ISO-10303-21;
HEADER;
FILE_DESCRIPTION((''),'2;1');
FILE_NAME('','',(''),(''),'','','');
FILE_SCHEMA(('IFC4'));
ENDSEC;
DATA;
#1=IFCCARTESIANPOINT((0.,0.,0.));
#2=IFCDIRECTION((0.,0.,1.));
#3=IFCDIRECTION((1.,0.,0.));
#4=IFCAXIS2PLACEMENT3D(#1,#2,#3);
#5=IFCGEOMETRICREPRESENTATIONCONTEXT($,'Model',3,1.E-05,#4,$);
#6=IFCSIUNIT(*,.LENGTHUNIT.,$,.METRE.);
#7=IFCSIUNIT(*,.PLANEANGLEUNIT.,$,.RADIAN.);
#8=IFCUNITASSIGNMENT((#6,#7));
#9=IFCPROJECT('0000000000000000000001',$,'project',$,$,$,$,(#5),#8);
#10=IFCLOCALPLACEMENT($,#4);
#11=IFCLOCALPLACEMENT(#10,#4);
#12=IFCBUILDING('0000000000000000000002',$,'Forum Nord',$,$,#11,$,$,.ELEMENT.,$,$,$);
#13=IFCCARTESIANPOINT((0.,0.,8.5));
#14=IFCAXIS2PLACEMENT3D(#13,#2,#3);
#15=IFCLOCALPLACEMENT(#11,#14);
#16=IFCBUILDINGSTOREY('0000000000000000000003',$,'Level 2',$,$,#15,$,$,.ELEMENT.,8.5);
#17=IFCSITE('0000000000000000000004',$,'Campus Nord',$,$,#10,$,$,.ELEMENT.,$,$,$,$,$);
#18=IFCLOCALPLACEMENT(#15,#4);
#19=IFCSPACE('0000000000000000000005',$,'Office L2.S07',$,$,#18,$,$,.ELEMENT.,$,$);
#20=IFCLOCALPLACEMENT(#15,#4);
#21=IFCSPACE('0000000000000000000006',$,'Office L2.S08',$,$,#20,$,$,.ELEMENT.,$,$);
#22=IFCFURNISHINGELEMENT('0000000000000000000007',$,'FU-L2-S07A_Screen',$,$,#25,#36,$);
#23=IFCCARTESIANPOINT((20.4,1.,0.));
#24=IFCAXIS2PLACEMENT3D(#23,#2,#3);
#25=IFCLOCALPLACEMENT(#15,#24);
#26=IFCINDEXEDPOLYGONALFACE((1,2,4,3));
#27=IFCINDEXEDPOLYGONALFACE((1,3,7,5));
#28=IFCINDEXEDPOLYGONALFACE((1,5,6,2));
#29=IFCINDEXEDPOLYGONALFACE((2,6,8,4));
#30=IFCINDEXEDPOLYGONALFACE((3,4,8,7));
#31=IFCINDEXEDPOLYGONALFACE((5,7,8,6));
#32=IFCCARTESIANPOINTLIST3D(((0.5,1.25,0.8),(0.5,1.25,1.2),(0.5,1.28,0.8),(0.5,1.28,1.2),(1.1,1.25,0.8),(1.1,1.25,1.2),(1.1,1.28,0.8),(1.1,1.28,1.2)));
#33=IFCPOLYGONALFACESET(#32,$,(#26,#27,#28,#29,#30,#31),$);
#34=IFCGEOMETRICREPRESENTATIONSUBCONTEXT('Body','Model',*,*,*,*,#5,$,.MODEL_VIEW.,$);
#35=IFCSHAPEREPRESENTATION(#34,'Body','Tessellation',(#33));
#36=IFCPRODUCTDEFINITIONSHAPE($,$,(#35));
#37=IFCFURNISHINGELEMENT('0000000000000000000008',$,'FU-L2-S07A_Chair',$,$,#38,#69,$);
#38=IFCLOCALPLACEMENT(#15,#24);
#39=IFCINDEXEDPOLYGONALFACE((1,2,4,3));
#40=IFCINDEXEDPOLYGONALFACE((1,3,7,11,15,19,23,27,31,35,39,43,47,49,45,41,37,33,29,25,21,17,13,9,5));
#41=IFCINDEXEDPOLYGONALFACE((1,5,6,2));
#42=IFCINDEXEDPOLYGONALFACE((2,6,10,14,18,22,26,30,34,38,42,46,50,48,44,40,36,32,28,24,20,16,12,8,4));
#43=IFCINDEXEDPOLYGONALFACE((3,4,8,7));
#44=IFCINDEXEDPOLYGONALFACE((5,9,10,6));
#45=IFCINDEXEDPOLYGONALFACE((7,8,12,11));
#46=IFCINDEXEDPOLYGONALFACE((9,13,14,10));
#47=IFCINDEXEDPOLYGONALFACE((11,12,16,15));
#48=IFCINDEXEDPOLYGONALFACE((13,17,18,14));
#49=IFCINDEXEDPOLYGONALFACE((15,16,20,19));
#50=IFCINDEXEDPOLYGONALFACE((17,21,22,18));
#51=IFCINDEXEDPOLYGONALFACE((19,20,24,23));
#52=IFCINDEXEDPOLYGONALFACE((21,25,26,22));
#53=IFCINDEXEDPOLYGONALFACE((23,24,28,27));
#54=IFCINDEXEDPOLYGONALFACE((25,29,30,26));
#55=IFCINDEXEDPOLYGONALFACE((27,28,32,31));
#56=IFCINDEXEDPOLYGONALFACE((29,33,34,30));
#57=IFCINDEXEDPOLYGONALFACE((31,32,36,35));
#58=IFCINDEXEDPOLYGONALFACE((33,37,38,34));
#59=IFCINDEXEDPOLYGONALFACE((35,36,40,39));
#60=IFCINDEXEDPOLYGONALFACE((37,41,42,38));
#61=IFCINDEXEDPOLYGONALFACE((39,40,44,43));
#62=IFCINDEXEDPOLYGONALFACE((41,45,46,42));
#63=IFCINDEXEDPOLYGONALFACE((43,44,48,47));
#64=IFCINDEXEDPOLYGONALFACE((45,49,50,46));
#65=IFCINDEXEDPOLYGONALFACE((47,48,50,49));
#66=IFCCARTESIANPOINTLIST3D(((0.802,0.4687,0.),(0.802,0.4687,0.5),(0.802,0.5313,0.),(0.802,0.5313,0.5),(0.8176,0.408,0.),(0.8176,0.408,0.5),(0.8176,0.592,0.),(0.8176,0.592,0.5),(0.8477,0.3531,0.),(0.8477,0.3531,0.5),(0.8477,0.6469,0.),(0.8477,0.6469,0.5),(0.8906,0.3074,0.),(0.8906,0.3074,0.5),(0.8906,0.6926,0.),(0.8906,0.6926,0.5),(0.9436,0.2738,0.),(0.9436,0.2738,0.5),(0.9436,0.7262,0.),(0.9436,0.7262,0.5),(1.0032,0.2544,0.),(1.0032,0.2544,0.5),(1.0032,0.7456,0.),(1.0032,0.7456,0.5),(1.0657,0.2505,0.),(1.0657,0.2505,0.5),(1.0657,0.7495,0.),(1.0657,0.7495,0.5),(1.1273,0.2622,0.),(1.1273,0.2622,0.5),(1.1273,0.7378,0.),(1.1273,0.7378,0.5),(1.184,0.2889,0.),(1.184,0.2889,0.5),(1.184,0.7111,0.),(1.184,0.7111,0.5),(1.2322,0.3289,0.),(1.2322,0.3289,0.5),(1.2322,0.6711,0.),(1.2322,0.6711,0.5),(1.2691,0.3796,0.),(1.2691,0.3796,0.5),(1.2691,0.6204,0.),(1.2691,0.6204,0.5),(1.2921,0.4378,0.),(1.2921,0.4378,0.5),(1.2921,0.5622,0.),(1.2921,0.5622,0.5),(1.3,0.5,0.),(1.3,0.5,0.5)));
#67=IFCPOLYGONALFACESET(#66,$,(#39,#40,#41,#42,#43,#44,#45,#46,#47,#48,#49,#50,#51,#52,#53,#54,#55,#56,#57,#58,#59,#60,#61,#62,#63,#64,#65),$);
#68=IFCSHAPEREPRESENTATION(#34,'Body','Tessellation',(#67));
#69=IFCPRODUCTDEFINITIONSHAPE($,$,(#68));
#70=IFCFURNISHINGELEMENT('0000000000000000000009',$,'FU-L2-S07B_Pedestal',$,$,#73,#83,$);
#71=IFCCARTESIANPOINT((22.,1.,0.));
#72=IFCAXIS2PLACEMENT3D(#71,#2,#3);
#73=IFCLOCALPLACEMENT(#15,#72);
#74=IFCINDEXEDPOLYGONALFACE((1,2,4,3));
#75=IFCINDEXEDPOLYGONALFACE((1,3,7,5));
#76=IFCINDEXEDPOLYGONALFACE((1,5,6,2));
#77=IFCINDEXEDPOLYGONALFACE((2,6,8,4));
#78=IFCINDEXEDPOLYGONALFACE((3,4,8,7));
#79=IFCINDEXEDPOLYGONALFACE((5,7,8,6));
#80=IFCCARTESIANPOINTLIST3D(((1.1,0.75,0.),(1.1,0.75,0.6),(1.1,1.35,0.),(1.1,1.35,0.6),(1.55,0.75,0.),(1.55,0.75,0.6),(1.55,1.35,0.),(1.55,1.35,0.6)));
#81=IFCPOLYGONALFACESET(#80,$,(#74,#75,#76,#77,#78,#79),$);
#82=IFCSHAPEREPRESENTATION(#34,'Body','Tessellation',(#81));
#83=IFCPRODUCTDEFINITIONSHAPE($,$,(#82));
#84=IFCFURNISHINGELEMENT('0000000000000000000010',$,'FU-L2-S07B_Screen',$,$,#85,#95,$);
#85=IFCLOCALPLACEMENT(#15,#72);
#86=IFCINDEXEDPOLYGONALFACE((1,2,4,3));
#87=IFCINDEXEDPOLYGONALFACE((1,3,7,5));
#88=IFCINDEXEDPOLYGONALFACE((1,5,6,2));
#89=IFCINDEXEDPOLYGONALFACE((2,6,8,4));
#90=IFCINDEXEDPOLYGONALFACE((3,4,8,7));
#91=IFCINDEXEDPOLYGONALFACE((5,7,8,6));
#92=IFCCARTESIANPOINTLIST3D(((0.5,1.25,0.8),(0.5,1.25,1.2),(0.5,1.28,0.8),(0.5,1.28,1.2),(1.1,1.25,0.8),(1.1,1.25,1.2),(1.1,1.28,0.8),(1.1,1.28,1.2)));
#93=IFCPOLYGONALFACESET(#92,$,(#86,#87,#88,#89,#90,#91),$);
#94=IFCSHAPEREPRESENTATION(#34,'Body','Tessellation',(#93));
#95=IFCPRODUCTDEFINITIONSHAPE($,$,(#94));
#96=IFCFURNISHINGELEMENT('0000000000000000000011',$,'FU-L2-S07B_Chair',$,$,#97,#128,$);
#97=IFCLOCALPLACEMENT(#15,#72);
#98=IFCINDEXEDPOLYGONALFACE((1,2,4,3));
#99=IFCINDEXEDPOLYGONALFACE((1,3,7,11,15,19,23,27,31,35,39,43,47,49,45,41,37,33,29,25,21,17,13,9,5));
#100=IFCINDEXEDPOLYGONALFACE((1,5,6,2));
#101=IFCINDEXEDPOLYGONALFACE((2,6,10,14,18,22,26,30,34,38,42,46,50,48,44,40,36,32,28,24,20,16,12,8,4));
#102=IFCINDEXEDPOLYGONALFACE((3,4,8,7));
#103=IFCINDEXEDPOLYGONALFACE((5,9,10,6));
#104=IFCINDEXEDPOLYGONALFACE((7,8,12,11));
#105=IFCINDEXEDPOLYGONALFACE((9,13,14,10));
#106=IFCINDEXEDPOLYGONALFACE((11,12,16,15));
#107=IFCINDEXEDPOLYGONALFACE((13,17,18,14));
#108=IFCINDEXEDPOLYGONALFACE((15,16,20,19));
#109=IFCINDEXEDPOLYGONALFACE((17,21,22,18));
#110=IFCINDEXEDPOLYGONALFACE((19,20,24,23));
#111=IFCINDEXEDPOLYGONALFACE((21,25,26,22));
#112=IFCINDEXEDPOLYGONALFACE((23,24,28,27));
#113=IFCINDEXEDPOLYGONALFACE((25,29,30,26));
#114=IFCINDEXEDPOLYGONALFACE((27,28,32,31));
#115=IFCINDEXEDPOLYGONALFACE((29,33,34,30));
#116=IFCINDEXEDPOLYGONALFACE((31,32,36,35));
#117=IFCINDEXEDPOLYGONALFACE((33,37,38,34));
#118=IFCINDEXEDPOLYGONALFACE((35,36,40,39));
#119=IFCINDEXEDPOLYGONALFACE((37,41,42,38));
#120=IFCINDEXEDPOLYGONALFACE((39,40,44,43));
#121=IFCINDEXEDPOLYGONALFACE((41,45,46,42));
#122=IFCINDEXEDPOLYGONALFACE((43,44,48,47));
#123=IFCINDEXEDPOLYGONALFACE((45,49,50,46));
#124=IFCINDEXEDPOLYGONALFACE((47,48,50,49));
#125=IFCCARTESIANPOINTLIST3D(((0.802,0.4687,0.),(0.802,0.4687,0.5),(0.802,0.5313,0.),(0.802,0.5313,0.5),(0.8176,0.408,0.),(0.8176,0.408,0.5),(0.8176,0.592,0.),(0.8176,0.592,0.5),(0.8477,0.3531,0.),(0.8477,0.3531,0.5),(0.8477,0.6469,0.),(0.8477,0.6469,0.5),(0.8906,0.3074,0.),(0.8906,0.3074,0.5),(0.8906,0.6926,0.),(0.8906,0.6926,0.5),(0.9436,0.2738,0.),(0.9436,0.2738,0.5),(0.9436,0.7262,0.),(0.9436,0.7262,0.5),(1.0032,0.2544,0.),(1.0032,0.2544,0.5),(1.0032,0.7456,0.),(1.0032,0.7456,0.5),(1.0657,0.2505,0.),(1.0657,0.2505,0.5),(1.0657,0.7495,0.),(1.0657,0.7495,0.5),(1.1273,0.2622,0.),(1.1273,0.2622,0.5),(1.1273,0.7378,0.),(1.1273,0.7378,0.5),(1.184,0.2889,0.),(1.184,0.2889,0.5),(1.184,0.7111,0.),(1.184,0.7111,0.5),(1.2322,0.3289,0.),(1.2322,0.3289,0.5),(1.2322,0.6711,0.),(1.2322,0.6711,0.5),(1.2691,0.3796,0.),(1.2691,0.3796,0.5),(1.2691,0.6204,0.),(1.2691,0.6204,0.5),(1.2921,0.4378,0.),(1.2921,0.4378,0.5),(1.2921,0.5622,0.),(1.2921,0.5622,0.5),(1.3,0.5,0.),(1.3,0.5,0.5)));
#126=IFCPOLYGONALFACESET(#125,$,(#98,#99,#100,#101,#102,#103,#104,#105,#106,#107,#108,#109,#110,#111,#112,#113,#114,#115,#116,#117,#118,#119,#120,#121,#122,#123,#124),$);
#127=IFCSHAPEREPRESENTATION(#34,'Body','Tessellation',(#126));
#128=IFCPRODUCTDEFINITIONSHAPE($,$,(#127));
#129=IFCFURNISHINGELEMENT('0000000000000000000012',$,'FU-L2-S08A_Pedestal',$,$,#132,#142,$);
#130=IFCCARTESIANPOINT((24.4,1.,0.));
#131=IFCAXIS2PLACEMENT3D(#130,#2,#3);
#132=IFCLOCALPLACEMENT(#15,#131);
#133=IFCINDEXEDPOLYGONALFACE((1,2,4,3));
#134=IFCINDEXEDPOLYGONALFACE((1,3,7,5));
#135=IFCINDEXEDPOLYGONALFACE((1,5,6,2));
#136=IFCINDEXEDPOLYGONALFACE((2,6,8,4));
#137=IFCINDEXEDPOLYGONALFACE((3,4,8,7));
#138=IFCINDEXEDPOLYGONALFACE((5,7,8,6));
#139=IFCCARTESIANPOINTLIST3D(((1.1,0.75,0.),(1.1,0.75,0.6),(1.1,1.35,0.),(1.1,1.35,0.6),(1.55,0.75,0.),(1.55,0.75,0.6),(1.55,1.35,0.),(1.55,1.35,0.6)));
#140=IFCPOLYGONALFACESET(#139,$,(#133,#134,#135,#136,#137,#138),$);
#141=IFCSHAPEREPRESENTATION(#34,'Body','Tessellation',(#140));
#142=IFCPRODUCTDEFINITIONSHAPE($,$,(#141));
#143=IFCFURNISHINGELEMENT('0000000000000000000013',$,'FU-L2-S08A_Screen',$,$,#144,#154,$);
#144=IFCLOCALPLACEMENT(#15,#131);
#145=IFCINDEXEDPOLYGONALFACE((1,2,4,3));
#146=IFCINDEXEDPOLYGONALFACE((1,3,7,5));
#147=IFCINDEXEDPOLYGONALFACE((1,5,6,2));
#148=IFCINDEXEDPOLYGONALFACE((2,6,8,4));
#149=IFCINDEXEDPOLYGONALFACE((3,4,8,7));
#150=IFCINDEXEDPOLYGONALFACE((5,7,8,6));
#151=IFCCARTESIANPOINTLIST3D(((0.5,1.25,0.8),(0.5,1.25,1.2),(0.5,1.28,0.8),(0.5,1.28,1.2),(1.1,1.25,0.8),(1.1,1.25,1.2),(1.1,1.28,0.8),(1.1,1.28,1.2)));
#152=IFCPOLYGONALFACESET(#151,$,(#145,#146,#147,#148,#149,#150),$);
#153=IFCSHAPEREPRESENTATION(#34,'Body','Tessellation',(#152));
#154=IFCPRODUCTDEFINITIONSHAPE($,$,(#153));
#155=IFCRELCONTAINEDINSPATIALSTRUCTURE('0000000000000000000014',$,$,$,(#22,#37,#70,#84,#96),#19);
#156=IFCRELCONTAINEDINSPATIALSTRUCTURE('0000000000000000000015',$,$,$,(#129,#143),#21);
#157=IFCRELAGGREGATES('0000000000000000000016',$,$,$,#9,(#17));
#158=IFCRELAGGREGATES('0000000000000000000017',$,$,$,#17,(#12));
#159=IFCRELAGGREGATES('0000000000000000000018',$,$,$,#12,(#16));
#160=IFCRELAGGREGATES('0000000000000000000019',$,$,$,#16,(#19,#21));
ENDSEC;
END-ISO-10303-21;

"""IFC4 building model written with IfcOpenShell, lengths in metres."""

from ifc_helpers import new_model, si_unit, frame, frame_2d, origin_with_axes, place, context, subcontext, project, spatial, rectangle, circle, extrude, element, save


model = new_model("IFC4")

# Units and contexts
model_context = context("Model", 3, precision=1e-05, world=origin_with_axes())
body_context = subcontext(model_context, "Body", "Model", "MODEL_VIEW")
ifc_project = project(units=[si_unit("LENGTHUNIT", "METRE"), si_unit("PLANEANGLEUNIT", "RADIAN")], contexts=[model_context])

# Site, building, storey
site_placement = place(None, origin_with_axes())
site = spatial("IfcSite", under=ifc_project, at=site_placement, Name="Campus Nord", CompositionType="ELEMENT")
building_placement = place(site_placement, origin_with_axes())
building = spatial("IfcBuilding", under=site, at=building_placement, Name="Forum Nord", CompositionType="ELEMENT")
storey_placement = place(building_placement, frame((0.0, 0.0, 8.5), z_axis=(0.0, 0.0, 1.0), x_axis=(1.0, 0.0, 0.0)))
storey = spatial("IfcBuildingStorey", under=building, at=storey_placement, Name="Level 2", CompositionType="ELEMENT", Elevation=8.5)

# Shared definitions
space_1_placement = place(storey_placement, origin_with_axes())
space_1 = spatial("IfcSpace", under=storey, at=space_1_placement, Name="Office L2.S07", CompositionType="ELEMENT")

# Furnishing elements
furnishing_1_placement = place(storey_placement, frame((20.4, 1.0, 0.0), z_axis=(0.0, 0.0, 1.0), x_axis=(1.0, 0.0, 0.0)))
element("IfcFurnishingElement", 1, at=furnishing_1_placement, inside=space_1, Name="FU-L2-S07A_Screen", context=body_context, shape_type="SweptSolid", body=[
    extrude(rectangle(XDim=0.6, YDim=0.03, at=frame_2d((0.8, 1.265), x_axis=(1.0, 0.0))), frame((0.0, 0.0, 0.8), z_axis=(0.0, 0.0, 1.0), x_axis=(1.0, 0.0, 0.0)), (0.0, 0.0, 1.0), 0.4),
])
furnishing_2_placement = place(storey_placement, frame((20.4, 1.0, 0.0), z_axis=(0.0, 0.0, 1.0), x_axis=(1.0, 0.0, 0.0)))
element("IfcFurnishingElement", 2, at=furnishing_2_placement, inside=space_1, Name="FU-L2-S07A_Chair", context=body_context, shape_type="SweptSolid", body=[
    extrude(circle(Radius=0.25, at=frame_2d((1.05, 0.5), x_axis=(1.0, 0.0))), origin_with_axes(), (0.0, 0.0, 1.0), 0.5),
])
furnishing_3_placement = place(storey_placement, frame((22.0, 1.0, 0.0), z_axis=(0.0, 0.0, 1.0), x_axis=(1.0, 0.0, 0.0)))
element("IfcFurnishingElement", 3, at=furnishing_3_placement, inside=space_1, Name="FU-L2-S07B_Pedestal", context=body_context, shape_type="SweptSolid", body=[
    extrude(rectangle(XDim=0.45, YDim=0.6, at=frame_2d((1.325, 1.05), x_axis=(1.0, 0.0))), origin_with_axes(), (0.0, 0.0, 1.0), 0.6),
])
furnishing_4_placement = place(storey_placement, frame((22.0, 1.0, 0.0), z_axis=(0.0, 0.0, 1.0), x_axis=(1.0, 0.0, 0.0)))
element("IfcFurnishingElement", 4, at=furnishing_4_placement, inside=space_1, Name="FU-L2-S07B_Screen", context=body_context, shape_type="SweptSolid", body=[
    extrude(rectangle(XDim=0.6, YDim=0.03, at=frame_2d((0.8, 1.265), x_axis=(1.0, 0.0))), frame((0.0, 0.0, 0.8), z_axis=(0.0, 0.0, 1.0), x_axis=(1.0, 0.0, 0.0)), (0.0, 0.0, 1.0), 0.4),
])
furnishing_5_placement = place(storey_placement, frame((22.0, 1.0, 0.0), z_axis=(0.0, 0.0, 1.0), x_axis=(1.0, 0.0, 0.0)))
element("IfcFurnishingElement", 5, at=furnishing_5_placement, inside=space_1, Name="FU-L2-S07B_Chair", context=body_context, shape_type="SweptSolid", body=[
    extrude(circle(Radius=0.25, at=frame_2d((1.05, 0.5), x_axis=(1.0, 0.0))), origin_with_axes(), (0.0, 0.0, 1.0), 0.5),
])

# Shared definitions
space_2_placement = place(storey_placement, origin_with_axes())
space_2 = spatial("IfcSpace", under=storey, at=space_2_placement, Name="Office L2.S08", CompositionType="ELEMENT")

# Furnishing elements
furnishing_6_placement = place(storey_placement, frame((24.4, 1.0, 0.0), z_axis=(0.0, 0.0, 1.0), x_axis=(1.0, 0.0, 0.0)))
element("IfcFurnishingElement", 6, at=furnishing_6_placement, inside=space_2, Name="FU-L2-S08A_Pedestal", context=body_context, shape_type="SweptSolid", body=[
    extrude(rectangle(XDim=0.45, YDim=0.6, at=frame_2d((1.325, 1.05), x_axis=(1.0, 0.0))), origin_with_axes(), (0.0, 0.0, 1.0), 0.6),
])
furnishing_7_placement = place(storey_placement, frame((24.4, 1.0, 0.0), z_axis=(0.0, 0.0, 1.0), x_axis=(1.0, 0.0, 0.0)))
element("IfcFurnishingElement", 7, at=furnishing_7_placement, inside=space_2, Name="FU-L2-S08A_Screen", context=body_context, shape_type="SweptSolid", body=[
    extrude(rectangle(XDim=0.6, YDim=0.03, at=frame_2d((0.8, 1.265), x_axis=(1.0, 0.0))), frame((0.0, 0.0, 0.8), z_axis=(0.0, 0.0, 1.0), x_axis=(1.0, 0.0, 0.0)), (0.0, 0.0, 1.0), 0.4),
])

save(model, "model.ifc")
